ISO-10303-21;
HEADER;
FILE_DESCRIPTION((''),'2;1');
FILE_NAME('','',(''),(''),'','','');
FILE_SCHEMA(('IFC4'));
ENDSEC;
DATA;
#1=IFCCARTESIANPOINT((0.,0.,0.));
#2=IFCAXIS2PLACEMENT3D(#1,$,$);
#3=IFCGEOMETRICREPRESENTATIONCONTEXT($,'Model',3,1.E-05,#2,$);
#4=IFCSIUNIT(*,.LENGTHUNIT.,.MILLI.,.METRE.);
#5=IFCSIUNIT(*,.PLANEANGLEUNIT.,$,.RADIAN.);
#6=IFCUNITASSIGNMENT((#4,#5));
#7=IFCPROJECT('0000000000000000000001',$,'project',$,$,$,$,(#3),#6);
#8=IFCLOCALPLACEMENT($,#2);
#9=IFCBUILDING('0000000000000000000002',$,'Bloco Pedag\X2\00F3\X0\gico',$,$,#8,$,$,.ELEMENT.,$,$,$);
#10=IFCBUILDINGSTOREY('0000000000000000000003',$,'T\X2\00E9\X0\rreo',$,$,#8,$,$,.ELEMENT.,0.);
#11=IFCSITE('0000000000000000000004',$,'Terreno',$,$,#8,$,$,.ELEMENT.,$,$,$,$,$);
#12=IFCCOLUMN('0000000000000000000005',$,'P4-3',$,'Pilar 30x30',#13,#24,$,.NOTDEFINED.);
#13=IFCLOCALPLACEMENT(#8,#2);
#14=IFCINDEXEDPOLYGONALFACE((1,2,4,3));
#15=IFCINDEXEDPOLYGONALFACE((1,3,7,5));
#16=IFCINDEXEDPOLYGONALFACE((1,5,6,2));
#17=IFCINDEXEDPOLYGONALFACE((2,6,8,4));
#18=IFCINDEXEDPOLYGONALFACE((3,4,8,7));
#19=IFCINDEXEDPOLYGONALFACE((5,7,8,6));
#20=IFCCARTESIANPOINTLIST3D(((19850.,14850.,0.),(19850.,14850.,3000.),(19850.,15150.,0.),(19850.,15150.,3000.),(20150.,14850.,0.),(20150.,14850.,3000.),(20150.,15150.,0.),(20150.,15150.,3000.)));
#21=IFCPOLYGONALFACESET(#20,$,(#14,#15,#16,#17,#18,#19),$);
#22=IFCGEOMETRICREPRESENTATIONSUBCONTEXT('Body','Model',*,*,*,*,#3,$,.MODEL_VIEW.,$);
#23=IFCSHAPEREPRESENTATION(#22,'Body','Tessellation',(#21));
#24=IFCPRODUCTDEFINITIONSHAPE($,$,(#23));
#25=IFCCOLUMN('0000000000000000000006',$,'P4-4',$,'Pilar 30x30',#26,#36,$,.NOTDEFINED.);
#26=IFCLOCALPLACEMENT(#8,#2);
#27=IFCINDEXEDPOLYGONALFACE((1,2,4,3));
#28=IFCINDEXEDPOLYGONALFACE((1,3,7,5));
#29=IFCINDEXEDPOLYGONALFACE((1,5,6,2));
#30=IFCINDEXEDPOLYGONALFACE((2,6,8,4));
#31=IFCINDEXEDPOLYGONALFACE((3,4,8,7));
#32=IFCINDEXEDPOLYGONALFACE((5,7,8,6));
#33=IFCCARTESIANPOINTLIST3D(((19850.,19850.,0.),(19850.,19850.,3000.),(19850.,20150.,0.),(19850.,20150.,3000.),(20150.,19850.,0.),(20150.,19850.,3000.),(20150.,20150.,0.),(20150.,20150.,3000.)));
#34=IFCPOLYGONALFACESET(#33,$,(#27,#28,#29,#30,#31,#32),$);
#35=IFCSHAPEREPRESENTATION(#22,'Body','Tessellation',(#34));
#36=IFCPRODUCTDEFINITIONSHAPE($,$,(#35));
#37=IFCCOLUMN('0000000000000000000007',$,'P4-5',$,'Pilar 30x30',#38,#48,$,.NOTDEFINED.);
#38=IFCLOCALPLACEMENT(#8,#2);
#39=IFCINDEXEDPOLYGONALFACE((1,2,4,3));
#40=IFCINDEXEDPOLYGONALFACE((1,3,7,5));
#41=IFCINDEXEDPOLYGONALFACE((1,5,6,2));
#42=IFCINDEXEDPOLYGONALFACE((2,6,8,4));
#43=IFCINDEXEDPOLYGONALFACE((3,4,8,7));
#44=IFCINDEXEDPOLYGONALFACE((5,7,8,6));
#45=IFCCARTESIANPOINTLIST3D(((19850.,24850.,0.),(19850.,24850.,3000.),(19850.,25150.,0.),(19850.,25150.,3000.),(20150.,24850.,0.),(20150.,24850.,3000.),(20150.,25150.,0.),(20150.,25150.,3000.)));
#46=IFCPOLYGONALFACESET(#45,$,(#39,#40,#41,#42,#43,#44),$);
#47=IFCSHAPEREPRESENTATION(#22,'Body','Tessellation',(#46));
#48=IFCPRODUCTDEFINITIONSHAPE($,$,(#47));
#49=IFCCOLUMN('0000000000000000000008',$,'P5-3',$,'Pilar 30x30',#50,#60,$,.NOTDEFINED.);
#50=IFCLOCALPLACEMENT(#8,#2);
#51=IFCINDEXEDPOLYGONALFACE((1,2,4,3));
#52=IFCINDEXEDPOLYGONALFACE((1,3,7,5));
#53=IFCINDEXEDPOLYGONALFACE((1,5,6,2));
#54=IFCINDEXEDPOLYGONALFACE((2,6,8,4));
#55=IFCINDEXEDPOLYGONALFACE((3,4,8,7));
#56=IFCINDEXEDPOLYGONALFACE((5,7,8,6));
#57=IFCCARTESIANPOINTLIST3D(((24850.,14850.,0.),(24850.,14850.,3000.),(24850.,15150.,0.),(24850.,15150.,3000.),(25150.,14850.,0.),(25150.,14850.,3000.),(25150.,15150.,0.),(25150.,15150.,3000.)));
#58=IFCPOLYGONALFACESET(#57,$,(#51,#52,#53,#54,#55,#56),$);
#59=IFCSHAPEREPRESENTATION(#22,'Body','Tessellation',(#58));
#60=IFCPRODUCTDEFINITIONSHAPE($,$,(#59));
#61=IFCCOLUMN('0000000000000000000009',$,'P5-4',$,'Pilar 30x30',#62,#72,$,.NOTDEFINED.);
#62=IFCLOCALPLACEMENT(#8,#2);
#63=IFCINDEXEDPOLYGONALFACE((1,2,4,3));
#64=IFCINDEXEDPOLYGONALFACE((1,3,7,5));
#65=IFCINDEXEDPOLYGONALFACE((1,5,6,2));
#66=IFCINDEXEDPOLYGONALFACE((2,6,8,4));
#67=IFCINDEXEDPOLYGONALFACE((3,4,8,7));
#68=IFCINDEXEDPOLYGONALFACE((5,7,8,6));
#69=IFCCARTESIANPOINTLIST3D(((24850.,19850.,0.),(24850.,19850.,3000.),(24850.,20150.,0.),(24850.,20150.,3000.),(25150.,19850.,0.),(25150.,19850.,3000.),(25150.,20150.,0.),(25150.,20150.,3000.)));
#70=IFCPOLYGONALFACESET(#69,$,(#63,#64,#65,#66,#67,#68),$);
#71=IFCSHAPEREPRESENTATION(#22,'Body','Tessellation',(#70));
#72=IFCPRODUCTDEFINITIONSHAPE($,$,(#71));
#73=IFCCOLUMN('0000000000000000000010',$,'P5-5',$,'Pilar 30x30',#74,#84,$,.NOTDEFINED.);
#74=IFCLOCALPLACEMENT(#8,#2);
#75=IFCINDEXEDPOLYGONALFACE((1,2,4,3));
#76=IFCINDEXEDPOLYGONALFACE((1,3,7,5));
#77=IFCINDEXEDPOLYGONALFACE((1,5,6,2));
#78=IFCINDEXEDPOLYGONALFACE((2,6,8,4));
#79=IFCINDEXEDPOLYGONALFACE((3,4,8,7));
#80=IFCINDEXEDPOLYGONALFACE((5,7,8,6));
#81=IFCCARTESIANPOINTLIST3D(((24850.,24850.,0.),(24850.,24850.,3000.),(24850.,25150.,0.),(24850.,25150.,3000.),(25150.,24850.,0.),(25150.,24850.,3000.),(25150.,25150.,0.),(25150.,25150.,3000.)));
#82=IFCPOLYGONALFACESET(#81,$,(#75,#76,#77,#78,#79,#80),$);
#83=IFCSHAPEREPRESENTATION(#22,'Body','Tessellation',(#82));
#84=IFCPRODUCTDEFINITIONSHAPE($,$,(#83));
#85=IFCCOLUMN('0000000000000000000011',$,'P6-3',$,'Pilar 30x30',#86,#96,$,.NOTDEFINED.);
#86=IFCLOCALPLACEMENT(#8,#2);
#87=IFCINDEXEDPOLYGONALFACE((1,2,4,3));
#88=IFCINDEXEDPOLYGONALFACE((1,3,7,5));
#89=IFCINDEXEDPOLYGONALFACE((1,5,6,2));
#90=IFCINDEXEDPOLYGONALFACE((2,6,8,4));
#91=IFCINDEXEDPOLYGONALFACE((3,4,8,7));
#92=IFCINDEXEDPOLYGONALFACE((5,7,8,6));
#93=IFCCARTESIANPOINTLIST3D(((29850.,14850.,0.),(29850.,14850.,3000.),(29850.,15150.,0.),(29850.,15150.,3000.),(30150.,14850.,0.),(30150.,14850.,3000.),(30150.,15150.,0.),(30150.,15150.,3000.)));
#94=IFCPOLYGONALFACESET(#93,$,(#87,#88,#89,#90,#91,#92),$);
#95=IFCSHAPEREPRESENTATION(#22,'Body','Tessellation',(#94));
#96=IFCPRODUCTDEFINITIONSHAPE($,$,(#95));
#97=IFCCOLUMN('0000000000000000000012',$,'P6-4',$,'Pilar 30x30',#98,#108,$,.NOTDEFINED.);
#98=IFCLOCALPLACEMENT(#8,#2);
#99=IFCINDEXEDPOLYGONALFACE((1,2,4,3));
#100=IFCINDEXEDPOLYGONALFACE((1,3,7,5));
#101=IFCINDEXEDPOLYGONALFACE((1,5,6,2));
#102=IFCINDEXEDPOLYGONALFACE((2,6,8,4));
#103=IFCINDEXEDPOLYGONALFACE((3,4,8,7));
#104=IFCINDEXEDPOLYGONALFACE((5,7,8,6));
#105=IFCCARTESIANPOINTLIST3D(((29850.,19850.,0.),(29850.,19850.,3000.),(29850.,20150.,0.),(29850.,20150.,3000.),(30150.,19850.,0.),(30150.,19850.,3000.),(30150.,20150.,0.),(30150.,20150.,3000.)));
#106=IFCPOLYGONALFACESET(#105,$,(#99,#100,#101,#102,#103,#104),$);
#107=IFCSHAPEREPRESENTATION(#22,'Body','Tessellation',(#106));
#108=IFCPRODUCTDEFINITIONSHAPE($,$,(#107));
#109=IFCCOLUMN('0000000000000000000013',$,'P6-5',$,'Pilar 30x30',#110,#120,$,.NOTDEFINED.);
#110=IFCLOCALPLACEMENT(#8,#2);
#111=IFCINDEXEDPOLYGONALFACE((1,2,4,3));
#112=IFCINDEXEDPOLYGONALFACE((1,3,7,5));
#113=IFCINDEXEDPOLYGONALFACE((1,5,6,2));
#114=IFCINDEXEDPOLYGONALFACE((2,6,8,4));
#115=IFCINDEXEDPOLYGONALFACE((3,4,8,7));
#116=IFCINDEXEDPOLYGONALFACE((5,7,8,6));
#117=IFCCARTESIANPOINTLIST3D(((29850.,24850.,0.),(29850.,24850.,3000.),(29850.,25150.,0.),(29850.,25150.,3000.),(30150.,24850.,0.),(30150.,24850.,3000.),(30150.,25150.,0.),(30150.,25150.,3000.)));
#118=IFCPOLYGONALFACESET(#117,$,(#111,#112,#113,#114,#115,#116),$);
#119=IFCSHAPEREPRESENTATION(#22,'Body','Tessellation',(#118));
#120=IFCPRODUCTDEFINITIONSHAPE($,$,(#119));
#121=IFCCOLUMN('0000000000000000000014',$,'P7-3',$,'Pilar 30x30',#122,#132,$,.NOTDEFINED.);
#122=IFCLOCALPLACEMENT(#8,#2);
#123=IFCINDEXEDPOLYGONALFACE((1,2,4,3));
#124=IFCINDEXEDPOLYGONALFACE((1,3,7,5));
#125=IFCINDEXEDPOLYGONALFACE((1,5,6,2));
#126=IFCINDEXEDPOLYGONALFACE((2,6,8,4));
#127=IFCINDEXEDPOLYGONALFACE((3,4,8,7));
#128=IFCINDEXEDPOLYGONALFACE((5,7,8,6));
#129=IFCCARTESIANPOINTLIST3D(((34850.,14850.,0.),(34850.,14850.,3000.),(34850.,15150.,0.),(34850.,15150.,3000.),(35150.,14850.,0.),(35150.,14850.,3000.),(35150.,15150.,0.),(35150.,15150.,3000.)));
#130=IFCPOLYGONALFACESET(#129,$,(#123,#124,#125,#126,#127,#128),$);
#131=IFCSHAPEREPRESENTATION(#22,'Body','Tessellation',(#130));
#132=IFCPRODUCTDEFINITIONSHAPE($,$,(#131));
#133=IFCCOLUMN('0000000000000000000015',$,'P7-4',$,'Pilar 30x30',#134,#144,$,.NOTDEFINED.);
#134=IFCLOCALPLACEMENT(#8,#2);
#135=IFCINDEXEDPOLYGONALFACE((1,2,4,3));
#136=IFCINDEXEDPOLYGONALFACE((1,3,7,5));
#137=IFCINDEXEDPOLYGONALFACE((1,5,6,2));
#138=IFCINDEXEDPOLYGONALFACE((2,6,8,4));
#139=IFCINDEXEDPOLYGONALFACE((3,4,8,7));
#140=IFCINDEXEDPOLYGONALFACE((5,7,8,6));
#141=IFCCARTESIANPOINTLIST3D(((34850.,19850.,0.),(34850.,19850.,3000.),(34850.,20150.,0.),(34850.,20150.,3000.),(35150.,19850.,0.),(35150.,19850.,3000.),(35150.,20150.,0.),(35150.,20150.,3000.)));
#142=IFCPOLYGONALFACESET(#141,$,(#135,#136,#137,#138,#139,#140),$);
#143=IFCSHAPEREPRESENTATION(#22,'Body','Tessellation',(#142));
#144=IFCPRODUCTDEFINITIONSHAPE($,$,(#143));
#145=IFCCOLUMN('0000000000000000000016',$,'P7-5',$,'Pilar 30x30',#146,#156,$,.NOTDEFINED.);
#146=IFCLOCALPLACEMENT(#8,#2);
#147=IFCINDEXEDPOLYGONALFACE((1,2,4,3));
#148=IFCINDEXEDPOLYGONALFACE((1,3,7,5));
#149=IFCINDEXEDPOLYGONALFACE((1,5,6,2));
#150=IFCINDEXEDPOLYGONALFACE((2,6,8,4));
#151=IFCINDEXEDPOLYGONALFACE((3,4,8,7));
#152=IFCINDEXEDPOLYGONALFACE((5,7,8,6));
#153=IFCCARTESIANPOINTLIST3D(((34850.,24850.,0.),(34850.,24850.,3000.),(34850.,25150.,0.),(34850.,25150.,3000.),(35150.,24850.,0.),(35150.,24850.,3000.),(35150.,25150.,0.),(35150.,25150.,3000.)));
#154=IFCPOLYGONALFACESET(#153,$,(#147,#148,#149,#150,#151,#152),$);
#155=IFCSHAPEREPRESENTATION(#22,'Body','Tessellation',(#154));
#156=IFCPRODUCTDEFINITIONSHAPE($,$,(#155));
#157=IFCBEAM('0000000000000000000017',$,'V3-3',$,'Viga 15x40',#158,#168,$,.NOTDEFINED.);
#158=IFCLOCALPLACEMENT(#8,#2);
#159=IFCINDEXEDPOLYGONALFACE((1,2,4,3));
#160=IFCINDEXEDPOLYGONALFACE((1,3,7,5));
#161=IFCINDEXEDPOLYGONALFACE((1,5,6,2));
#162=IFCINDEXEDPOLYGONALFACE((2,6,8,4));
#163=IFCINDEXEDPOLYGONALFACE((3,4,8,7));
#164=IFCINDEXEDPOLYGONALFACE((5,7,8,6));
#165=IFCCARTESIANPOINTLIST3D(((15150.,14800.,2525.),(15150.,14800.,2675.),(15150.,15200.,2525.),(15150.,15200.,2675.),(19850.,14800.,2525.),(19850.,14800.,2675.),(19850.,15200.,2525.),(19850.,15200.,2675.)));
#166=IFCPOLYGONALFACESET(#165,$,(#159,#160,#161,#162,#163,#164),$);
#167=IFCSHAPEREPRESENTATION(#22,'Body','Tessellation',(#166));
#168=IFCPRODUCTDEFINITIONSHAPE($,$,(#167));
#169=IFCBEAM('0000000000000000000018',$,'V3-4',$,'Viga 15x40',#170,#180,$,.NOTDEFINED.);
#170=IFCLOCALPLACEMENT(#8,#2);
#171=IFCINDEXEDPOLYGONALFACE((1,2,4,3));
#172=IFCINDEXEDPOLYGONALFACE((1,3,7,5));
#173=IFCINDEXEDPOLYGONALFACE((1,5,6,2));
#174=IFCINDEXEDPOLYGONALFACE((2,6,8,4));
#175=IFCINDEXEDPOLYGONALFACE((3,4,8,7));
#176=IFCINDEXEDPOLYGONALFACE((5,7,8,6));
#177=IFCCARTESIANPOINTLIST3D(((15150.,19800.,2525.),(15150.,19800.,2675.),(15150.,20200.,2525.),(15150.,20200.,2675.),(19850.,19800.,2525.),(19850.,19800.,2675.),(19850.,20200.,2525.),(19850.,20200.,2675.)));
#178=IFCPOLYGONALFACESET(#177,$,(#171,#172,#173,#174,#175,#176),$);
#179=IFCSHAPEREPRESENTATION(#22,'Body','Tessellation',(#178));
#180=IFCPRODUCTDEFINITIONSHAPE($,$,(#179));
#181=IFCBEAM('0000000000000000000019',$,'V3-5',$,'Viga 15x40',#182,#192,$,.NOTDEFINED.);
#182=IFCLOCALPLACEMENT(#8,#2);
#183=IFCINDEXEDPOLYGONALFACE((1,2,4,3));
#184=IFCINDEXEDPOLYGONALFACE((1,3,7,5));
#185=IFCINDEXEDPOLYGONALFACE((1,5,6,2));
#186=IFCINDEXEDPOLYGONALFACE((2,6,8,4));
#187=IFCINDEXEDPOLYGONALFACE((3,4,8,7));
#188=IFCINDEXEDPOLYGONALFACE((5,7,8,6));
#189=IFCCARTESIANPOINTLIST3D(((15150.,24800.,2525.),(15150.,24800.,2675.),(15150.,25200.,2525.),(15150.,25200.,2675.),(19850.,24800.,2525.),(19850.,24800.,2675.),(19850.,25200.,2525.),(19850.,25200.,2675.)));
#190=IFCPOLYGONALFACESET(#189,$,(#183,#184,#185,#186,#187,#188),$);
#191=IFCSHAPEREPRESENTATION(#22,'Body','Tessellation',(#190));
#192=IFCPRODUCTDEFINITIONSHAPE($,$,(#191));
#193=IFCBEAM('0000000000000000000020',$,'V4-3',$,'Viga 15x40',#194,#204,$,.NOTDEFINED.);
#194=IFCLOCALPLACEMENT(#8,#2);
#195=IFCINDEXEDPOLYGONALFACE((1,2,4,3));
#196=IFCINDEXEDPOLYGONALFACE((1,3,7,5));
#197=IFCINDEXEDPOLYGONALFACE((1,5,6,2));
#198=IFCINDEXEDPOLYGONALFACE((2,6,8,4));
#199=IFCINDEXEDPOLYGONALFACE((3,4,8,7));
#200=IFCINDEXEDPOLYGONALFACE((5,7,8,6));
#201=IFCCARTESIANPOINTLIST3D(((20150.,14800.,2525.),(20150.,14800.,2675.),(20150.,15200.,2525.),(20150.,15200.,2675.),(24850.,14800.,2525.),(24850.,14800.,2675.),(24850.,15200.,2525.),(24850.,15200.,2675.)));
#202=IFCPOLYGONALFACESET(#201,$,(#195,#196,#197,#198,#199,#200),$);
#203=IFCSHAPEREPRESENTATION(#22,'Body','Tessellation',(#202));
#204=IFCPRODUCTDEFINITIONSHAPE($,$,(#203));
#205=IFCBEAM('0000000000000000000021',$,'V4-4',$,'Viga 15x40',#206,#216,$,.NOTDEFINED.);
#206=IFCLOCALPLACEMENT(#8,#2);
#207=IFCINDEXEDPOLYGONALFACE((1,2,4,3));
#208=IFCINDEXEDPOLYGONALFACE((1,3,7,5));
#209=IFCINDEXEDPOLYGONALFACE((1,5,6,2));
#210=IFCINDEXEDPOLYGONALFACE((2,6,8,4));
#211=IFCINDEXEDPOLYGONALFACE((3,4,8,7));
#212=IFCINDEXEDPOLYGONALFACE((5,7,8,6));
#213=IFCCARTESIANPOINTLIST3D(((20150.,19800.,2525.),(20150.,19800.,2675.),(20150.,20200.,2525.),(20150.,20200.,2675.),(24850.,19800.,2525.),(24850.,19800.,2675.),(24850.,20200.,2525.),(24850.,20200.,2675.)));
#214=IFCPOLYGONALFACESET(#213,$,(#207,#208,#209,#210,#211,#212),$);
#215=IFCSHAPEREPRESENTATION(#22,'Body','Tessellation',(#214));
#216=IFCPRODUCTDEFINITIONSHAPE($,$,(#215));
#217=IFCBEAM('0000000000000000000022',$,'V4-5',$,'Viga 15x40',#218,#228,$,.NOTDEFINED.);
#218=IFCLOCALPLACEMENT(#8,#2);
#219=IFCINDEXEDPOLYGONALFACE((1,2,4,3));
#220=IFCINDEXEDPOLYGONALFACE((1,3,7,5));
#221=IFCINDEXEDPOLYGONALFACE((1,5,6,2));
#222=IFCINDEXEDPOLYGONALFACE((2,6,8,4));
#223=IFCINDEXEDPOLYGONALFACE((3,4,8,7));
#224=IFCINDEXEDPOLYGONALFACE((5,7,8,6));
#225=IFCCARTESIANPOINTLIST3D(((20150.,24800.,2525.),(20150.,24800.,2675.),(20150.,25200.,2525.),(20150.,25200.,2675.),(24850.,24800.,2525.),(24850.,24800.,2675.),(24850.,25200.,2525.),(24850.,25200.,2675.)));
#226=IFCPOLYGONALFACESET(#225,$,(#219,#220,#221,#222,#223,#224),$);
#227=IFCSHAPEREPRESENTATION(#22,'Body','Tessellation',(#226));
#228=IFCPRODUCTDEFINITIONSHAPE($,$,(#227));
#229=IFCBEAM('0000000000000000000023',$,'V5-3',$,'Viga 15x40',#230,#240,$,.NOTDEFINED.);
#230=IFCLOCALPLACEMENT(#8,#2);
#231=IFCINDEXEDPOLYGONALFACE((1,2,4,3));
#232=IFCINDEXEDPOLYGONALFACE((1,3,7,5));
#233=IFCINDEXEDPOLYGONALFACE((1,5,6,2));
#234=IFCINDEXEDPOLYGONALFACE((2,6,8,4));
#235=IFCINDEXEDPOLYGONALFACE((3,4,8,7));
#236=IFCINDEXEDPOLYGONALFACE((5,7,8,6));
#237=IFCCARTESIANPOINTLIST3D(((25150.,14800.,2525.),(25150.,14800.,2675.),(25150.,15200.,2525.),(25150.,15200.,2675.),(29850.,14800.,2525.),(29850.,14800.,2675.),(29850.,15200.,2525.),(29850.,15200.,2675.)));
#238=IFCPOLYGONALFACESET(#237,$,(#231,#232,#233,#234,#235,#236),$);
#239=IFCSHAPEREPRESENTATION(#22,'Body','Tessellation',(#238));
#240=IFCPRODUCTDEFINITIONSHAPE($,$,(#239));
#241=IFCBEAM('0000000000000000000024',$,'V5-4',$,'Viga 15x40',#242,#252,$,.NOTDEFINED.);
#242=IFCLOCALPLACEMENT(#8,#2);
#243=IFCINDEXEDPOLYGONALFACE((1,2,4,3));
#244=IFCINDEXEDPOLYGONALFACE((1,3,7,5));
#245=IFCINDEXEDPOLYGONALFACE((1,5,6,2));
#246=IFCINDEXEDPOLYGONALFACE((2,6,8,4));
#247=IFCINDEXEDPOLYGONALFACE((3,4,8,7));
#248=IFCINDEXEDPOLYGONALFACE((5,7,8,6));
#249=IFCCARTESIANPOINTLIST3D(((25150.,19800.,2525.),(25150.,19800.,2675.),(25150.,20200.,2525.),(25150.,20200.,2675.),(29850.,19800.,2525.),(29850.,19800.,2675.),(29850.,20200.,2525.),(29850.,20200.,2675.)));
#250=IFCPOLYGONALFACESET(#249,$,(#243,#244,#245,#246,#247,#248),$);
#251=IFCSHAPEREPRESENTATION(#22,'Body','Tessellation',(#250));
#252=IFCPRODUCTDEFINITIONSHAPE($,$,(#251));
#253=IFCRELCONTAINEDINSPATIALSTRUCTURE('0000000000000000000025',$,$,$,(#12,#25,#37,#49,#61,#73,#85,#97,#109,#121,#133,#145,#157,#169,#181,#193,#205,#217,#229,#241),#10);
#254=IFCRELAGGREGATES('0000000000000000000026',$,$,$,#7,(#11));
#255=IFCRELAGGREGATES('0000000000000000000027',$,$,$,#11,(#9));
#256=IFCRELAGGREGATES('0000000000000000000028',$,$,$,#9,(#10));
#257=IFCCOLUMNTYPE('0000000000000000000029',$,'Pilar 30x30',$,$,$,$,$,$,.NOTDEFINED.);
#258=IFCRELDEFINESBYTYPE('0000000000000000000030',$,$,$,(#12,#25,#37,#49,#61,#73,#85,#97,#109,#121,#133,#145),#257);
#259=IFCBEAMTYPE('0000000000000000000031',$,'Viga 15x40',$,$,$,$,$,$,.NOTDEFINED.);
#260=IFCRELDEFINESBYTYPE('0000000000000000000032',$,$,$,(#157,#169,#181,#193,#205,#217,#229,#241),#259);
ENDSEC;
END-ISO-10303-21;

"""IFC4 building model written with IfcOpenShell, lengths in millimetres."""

from ifc_helpers import new_model, si_unit, frame, origin, origin_2d, place, context, subcontext, project, spatial, rectangle, extrude, type_object, element, save


model = new_model("IFC4")

# Units and contexts
model_context = context("Model", 3, precision=1e-05, world=origin())
body_context = subcontext(model_context, "Body", "Model", "MODEL_VIEW")
ifc_project = project(units=[si_unit("LENGTHUNIT", "METRE", prefix="MILLI"), si_unit("PLANEANGLEUNIT", "RADIAN")], contexts=[model_context])

# Site, building, storey
placement = place(None, origin())
site = spatial("IfcSite", under=ifc_project, at=placement, Name="Terreno", CompositionType="ELEMENT")
building = spatial("IfcBuilding", under=site, at=placement, Name="Bloco Pedagógico", CompositionType="ELEMENT")
storey = spatial("IfcBuildingStorey", under=building, at=placement, Name="Térreo", CompositionType="ELEMENT", Elevation=0.0)

# Columns
column_type = type_object("IfcColumnType", Name="Pilar 30x30", PredefinedType="NOTDEFINED")
for number, where, z_axis, x_axis, name in (
    (1, (20000.0, 15000.0, 0.0), (0.0, 0.0, 1.0), (1.0, 0.0, 0.0), "P4-3"),
    (2, (20000.0, 20000.0, 0.0), (0.0, 0.0, 1.0), (1.0, 0.0, 0.0), "P4-4"),
    (3, (20000.0, 25000.0, 0.0), (0.0, 0.0, 1.0), (1.0, 0.0, 0.0), "P4-5"),
    (4, (25000.0, 15000.0, 0.0), (0.0, 0.0, 1.0), (1.0, 0.0, 0.0), "P5-3"),
    (5, (25000.0, 20000.0, 0.0), (0.0, 0.0, 1.0), (1.0, 0.0, 0.0), "P5-4"),
    (6, (25000.0, 25000.0, 0.0), (0.0, 0.0, 1.0), (1.0, 0.0, 0.0), "P5-5"),
    (7, (30000.0, 15000.0, 0.0), (0.0, 0.0, 1.0), (1.0, 0.0, 0.0), "P6-3"),
    (8, (30000.0, 20000.0, 0.0), (0.0, 0.0, 1.0), (1.0, 0.0, 0.0), "P6-4"),
    (9, (30000.0, 25000.0, 0.0), (0.0, 0.0, 1.0), (1.0, 0.0, 0.0), "P6-5"),
    (10, (35000.0, 15000.0, 0.0), (0.0, 0.0, 1.0), (1.0, 0.0, 0.0), "P7-3"),
    (11, (35000.0, 20000.0, 0.0), (0.0, 0.0, 1.0), (1.0, 0.0, 0.0), "P7-4"),
    (12, (35000.0, 25000.0, 0.0), (0.0, 0.0, 1.0), (1.0, 0.0, 0.0), "P7-5"),
):
    element("IfcColumn", number, at=place(None, frame(where, z_axis=z_axis, x_axis=x_axis)), inside=storey, type_object=column_type, Name=name, ObjectType="Pilar 30x30", PredefinedType="NOTDEFINED", context=body_context, shape_type="SweptSolid", body=[
        extrude(rectangle(XDim=300.0, YDim=300.0, at=origin_2d()), None, (0.0, 0.0, 1.0), 3000.0),
    ])

# Beams
beam_type = type_object("IfcBeamType", Name="Viga 15x40", PredefinedType="NOTDEFINED")
for number, where, z_axis, x_axis, name in (
    (13, (15150.0, 15000.0, 2600.0), (1.0, 0.0, 0.0), (0.0, 1.0, 0.0), "V3-3"),
    (14, (15150.0, 20000.0, 2600.0), (1.0, 0.0, 0.0), (0.0, 1.0, 0.0), "V3-4"),
    (15, (15150.0, 25000.0, 2600.0), (1.0, 0.0, 0.0), (0.0, 1.0, 0.0), "V3-5"),
    (16, (20150.0, 15000.0, 2600.0), (1.0, 0.0, 0.0), (0.0, 1.0, 0.0), "V4-3"),
    (17, (20150.0, 20000.0, 2600.0), (1.0, 0.0, 0.0), (0.0, 1.0, 0.0), "V4-4"),
    (18, (20150.0, 25000.0, 2600.0), (1.0, 0.0, 0.0), (0.0, 1.0, 0.0), "V4-5"),
    (19, (25150.0, 15000.0, 2600.0), (1.0, 0.0, 0.0), (0.0, 1.0, 0.0), "V5-3"),
    (20, (25150.0, 20000.0, 2600.0), (1.0, 0.0, 0.0), (0.0, 1.0, 0.0), "V5-4"),
):
    element("IfcBeam", number, at=place(None, frame(where, z_axis=z_axis, x_axis=x_axis)), inside=storey, type_object=beam_type, Name=name, ObjectType="Viga 15x40", PredefinedType="NOTDEFINED", context=body_context, shape_type="SweptSolid", body=[
        extrude(rectangle(XDim=400.0, YDim=150.0, at=origin_2d()), None, (0.0, 0.0, 1.0), 4700.0),
    ])

save(model, "model.ifc")
